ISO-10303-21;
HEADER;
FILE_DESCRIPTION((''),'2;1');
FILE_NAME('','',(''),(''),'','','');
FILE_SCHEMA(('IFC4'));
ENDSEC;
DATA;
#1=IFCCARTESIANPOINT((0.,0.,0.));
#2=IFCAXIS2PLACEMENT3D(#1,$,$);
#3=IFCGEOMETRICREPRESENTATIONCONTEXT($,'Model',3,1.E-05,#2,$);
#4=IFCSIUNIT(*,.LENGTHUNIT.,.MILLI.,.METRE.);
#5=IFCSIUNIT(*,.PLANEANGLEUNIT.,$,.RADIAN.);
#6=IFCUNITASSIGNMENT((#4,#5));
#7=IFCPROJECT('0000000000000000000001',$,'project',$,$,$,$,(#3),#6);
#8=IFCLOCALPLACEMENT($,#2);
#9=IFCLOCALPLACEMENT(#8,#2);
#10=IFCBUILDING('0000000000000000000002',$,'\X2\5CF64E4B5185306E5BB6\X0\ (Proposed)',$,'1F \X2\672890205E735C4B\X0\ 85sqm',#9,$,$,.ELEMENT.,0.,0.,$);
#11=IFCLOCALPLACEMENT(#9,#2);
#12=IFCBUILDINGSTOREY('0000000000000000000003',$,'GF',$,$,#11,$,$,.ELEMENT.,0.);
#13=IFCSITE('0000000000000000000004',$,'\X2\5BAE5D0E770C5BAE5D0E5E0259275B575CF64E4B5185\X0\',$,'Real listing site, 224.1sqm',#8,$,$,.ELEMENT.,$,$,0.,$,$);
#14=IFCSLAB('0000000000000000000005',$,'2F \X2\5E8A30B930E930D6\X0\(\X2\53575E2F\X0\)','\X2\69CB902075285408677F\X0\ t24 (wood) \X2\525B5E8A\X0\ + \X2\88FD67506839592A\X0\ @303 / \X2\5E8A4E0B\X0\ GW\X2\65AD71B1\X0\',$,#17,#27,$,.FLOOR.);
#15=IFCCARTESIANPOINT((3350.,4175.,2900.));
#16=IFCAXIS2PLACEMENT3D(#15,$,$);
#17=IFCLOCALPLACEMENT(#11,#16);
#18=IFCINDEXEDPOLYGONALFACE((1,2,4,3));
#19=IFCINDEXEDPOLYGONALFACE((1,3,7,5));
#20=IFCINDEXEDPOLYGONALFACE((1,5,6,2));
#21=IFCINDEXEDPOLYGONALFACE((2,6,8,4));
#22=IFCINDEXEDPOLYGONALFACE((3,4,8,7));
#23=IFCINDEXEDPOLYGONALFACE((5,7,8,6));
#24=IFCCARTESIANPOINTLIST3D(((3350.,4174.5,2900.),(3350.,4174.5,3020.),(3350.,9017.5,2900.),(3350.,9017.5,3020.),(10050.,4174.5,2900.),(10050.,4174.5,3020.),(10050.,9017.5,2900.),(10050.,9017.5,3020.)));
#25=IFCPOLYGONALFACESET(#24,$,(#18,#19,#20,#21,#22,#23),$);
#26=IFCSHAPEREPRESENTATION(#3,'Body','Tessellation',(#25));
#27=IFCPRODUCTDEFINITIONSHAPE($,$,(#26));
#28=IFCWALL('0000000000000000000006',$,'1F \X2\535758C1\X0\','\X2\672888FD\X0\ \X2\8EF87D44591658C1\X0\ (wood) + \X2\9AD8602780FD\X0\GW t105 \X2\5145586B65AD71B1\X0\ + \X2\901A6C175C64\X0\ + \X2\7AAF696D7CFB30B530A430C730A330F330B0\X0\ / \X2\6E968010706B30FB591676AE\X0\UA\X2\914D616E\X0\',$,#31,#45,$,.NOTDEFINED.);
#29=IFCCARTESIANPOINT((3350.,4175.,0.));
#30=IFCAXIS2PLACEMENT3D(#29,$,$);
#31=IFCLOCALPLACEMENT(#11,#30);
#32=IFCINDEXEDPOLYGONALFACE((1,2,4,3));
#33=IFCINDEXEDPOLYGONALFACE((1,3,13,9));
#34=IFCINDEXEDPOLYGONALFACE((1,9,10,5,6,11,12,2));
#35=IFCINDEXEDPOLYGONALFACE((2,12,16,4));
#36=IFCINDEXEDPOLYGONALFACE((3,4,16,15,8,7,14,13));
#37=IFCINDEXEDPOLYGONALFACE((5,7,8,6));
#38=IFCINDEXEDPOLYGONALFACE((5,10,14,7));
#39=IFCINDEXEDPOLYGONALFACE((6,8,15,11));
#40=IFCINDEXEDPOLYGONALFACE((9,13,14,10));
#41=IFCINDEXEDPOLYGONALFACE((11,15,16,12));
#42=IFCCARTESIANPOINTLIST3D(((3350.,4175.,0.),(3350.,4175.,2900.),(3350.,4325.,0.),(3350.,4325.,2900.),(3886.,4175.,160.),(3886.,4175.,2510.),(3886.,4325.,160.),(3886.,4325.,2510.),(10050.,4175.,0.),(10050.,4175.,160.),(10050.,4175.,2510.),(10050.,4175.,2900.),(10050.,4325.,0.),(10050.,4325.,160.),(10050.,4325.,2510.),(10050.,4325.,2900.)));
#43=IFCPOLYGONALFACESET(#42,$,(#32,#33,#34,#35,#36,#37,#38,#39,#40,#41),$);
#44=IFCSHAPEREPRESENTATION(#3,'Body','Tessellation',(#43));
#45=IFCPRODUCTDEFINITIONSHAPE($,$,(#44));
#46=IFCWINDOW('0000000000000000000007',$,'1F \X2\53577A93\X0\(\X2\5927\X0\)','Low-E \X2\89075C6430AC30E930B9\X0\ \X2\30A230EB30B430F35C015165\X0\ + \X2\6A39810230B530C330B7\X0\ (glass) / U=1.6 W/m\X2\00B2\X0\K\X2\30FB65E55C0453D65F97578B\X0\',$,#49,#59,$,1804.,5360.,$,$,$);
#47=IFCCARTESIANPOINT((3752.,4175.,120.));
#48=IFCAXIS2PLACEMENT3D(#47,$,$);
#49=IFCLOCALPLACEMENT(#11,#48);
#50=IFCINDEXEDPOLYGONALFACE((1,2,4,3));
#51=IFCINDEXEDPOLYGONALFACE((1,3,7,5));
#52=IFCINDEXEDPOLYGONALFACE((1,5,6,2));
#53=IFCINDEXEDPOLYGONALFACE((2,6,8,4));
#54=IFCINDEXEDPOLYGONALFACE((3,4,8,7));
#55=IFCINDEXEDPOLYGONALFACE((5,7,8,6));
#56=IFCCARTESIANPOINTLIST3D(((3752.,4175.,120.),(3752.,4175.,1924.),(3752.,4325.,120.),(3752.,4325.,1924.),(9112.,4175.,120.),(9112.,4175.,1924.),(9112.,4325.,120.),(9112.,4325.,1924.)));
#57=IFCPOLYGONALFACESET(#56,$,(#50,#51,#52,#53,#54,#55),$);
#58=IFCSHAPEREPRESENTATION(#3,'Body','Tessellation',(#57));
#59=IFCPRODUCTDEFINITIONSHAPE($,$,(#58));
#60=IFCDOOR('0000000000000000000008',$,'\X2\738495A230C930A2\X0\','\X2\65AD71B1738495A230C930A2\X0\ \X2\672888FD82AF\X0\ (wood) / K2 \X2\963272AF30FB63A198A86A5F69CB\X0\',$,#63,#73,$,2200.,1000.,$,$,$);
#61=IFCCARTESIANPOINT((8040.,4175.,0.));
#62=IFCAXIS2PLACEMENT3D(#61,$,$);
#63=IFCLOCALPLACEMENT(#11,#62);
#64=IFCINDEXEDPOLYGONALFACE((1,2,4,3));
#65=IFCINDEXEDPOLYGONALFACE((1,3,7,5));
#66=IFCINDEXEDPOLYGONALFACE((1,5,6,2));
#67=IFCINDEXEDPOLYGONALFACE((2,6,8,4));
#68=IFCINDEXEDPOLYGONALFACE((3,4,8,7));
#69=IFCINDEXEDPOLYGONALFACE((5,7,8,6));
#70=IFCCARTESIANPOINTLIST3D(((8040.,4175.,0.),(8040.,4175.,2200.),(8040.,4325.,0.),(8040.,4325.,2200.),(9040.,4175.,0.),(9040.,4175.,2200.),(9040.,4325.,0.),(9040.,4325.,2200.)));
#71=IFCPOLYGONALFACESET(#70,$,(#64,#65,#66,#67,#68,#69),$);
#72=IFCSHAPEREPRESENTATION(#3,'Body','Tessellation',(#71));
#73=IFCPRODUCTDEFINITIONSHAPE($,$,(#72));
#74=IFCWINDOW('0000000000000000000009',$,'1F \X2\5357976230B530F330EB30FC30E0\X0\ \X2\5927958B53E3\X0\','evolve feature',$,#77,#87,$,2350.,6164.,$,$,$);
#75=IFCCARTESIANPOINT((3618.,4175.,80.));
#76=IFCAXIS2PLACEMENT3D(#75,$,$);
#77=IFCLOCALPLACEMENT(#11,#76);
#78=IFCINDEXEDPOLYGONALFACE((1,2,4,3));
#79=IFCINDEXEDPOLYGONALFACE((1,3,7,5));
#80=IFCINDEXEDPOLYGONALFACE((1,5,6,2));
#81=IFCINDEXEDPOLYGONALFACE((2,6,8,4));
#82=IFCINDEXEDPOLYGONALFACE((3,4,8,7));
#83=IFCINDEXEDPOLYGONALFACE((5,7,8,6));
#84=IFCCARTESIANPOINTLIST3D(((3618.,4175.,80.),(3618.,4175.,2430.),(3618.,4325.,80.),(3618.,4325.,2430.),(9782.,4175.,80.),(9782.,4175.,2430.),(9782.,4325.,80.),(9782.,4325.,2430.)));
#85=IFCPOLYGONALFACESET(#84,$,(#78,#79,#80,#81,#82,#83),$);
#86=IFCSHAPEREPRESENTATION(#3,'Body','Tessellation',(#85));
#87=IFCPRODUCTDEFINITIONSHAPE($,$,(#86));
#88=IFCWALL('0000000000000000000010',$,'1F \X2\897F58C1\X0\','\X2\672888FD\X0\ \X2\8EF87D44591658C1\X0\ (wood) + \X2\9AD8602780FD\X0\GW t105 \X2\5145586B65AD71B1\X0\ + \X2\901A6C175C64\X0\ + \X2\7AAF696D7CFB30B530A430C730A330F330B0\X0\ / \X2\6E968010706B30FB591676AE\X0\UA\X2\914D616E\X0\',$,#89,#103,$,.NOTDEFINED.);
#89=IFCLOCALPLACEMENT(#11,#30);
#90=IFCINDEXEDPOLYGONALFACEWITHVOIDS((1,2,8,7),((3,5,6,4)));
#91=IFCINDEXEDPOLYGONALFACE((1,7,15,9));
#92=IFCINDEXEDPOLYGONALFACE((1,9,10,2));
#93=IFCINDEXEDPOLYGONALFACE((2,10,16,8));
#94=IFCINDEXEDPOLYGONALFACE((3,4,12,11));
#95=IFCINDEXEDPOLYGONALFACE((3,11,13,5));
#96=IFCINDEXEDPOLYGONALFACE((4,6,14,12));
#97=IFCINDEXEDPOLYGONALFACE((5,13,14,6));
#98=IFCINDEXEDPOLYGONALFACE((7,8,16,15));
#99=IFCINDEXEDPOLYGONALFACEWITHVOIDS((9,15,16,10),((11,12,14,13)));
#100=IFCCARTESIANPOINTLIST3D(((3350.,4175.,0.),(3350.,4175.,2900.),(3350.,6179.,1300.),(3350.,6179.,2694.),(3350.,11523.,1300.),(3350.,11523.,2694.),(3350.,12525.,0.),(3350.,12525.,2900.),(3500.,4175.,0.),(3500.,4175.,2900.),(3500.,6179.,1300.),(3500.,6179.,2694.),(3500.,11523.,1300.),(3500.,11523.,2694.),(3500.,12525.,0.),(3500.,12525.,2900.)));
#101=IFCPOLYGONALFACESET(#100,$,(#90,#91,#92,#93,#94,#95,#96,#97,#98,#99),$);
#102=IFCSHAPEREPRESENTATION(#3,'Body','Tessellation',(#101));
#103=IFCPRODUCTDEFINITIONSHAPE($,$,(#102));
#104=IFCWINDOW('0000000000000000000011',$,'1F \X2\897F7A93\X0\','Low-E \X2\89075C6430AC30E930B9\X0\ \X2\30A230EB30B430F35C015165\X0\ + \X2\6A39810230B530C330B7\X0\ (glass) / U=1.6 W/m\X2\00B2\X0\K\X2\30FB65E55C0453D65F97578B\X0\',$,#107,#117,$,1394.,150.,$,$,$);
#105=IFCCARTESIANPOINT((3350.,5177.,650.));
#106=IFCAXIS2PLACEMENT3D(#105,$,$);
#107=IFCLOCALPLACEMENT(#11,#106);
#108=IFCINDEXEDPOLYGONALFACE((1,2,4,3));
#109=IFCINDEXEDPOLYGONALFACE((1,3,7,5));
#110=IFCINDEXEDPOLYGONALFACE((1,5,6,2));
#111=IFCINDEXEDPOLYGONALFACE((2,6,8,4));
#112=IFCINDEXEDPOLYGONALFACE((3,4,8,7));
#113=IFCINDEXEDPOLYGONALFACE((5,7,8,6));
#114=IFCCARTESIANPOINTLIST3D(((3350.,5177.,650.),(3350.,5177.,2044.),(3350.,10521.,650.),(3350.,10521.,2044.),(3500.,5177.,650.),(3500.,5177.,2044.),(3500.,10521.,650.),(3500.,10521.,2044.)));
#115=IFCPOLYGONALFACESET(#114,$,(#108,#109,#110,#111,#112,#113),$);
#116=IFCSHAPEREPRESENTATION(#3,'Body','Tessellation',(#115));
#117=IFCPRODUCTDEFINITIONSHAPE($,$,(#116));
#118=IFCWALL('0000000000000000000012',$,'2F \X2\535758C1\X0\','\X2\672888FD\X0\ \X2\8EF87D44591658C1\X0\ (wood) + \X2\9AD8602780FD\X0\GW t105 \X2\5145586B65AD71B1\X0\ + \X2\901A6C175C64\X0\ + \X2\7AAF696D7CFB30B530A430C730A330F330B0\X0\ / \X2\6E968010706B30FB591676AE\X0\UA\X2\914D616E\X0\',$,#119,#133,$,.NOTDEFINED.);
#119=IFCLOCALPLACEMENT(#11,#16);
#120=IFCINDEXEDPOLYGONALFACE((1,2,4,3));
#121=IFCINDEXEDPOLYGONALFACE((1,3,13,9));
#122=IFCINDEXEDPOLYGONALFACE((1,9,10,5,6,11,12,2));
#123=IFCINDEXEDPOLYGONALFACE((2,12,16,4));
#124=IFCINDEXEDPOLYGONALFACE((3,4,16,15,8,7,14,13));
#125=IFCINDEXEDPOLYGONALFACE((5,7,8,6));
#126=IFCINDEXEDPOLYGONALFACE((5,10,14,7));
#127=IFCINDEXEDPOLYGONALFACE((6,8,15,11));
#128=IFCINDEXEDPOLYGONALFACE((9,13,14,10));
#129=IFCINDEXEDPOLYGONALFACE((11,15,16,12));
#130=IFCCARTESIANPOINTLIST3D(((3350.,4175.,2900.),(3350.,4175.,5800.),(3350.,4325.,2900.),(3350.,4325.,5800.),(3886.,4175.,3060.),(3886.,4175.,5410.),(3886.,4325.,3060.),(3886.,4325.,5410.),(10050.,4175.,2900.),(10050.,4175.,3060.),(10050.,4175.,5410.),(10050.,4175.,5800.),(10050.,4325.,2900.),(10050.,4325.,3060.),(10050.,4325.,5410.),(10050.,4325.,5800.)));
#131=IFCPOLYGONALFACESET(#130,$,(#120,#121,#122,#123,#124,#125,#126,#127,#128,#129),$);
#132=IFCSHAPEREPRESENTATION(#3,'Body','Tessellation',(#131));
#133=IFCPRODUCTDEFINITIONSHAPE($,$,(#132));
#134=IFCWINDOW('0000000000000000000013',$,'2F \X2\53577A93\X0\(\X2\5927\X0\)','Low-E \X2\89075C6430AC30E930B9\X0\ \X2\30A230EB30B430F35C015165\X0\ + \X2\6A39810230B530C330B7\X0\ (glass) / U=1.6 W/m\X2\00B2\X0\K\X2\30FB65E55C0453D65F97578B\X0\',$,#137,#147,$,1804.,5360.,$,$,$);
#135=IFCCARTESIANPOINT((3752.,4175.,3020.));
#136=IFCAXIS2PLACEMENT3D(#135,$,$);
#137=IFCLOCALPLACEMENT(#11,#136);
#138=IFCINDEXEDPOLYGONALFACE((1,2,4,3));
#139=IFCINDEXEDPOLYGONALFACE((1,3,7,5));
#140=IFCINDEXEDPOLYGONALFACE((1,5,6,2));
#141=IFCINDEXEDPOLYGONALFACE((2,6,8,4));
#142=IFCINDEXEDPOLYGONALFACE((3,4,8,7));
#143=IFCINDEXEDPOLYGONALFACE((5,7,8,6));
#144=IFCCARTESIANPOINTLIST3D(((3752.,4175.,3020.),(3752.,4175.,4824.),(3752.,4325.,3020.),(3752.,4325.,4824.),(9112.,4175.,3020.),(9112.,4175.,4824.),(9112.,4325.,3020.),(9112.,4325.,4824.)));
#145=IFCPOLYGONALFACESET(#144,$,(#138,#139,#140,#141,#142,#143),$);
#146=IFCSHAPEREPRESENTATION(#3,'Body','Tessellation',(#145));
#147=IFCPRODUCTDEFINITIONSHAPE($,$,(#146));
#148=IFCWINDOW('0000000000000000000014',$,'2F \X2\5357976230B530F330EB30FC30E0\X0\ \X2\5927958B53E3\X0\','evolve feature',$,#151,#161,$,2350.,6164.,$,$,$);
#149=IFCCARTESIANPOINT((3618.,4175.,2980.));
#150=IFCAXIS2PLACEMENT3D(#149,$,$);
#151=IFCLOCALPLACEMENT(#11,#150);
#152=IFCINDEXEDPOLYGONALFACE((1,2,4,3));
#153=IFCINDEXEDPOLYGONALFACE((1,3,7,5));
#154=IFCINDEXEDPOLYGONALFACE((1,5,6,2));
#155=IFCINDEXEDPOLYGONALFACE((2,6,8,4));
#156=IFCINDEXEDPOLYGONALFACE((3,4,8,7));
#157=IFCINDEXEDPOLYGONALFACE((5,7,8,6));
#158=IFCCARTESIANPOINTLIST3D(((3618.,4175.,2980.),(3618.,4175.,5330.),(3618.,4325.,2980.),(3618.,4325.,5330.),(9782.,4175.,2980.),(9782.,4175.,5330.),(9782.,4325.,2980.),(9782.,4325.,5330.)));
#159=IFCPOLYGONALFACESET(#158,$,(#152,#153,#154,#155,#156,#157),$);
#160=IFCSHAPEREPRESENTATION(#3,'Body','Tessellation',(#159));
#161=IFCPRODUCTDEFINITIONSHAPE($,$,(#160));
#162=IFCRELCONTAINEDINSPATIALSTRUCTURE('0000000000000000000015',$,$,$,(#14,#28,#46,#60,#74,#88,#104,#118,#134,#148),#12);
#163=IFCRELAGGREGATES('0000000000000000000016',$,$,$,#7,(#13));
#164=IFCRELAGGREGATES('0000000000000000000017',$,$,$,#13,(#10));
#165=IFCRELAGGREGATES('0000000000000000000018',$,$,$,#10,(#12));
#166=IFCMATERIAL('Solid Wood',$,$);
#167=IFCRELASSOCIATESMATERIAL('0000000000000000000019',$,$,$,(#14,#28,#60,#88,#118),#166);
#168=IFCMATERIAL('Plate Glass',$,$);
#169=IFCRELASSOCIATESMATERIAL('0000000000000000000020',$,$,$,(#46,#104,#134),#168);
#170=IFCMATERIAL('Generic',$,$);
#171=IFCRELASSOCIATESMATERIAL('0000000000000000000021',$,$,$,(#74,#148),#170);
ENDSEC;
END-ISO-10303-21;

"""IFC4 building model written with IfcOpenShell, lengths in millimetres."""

from ifc_helpers import new_model, si_unit, frame, frame_2d, origin, place, context, project, spatial, rectangle, extrude, material, element, fill, save


model = new_model("IFC4")

# Units and contexts
model_context = context("Model", 3, precision=1e-05, world=origin())
ifc_project = project(units=[si_unit("LENGTHUNIT", "METRE", prefix="MILLI"), si_unit("PLANEANGLEUNIT", "RADIAN")], contexts=[model_context])

# Site, building, storey
site_placement = place(None, origin())
site = spatial("IfcSite", under=ifc_project, at=site_placement, Name="宮崎県宮崎市大字島之内", ObjectType="Real listing site, 224.1sqm", CompositionType="ELEMENT", RefElevation=0.0)
building_placement = place(site_placement, origin())
building = spatial("IfcBuilding", under=site, at=building_placement, Name="島之内の家 (Proposed)", ObjectType="1F 木造平屋 85sqm", CompositionType="ELEMENT", ElevationOfRefHeight=0.0, ElevationOfTerrain=0.0)
storey_placement = place(building_placement, origin())
storey = spatial("IfcBuildingStorey", under=building, at=storey_placement, Name="GF", CompositionType="ELEMENT", Elevation=0.0)

# Slab
ifc_material_1 = material(Name="Solid Wood")
slab_1_placement = place(storey_placement, frame((3350.0, 4175.0, 2900.0)))
element("IfcSlab", 1, at=slab_1_placement, inside=storey, material=ifc_material_1, Name="2F 床スラブ(南帯)", Description="構造用合板 t24 (wood) 剛床 + 製材根太 @303 / 床下 GW断熱", PredefinedType="FLOOR", context=model_context, shape_type="SweptSolid", body=[
    extrude(rectangle(XDim=6700.0, YDim=4843.0, at=frame_2d((3350.0, 2421.0))), frame((3350.0, 4175.0, 2900.0)), (0.0, 0.0, 1.0), 120.0),
])
ifc_material_2 = material(Name="Generic")

# Wall, openings, windows, door
wall_1_placement = place(storey_placement, frame((3350.0, 4175.0, 0.0)))
wall_1 = element("IfcWall", 2, at=wall_1_placement, inside=storey, material=ifc_material_1, Name="1F 南壁", Description="木製 軸組外壁 (wood) + 高性能GW t105 充填断熱 + 通気層 + 窯業系サイディング / 準耐火・外皮UA配慮", PredefinedType="NOTDEFINED", context=model_context, shape_type="SweptSolid", body=[
    extrude(rectangle(XDim=6700.0, YDim=150.0, at=frame_2d((3350.0, 75.0))), frame((3350.0, 4175.0, 0.0)), (0.0, 0.0, 1.0), 2900.0),
])
opening_1_placement = place(storey_placement, frame((3752.0, 4175.0, 120.0)))
opening_1 = element("IfcOpeningElement", 3, at=opening_1_placement, cuts=wall_1, PredefinedType="NOTDEFINED", context=model_context, shape_type="SweptSolid", body=[
    extrude(rectangle(XDim=5360.0, YDim=150.0, at=frame_2d((2680.0, 75.0))), frame((3752.0, 4175.0, 120.0)), (0.0, 0.0, 1.0), 1804.0),
])
opening_2_placement = place(storey_placement, frame((8040.0, 4175.0, 0.0)))
opening_2 = element("IfcOpeningElement", 4, at=opening_2_placement, cuts=wall_1, PredefinedType="NOTDEFINED", context=model_context, shape_type="SweptSolid", body=[
    extrude(rectangle(XDim=1000.0, YDim=150.0, at=frame_2d((500.0, 75.0))), frame((8040.0, 4175.0, 0.0)), (0.0, 0.0, 1.0), 2200.0),
])
opening_3_placement = place(storey_placement, frame((3618.0, 4175.0, 80.0)))
opening_3 = element("IfcOpeningElement", 5, at=opening_3_placement, cuts=wall_1, PredefinedType="NOTDEFINED", context=model_context, shape_type="SweptSolid", body=[
    extrude(rectangle(XDim=6164.0, YDim=150.0, at=frame_2d((3082.0, 75.0))), frame((3618.0, 4175.0, 80.0)), (0.0, 0.0, 1.0), 2350.0),
])
ifc_material_3 = material(Name="Plate Glass")
window_1_placement = place(storey_placement, frame((3752.0, 4175.0, 120.0)))
window_1 = element("IfcWindow", 6, at=window_1_placement, inside=storey, material=ifc_material_3, Name="1F 南窓(大)", Description="Low-E 複層ガラス アルゴン封入 + 樹脂サッシ (glass) / U=1.6 W/m²K・日射取得型", OverallHeight=1804.0, OverallWidth=5360.0, context=model_context, shape_type="SweptSolid", body=[
    extrude(rectangle(XDim=5360.0, YDim=150.0, at=frame_2d((2680.0, 75.0))), frame((3752.0, 4175.0, 120.0)), (0.0, 0.0, 1.0), 1804.0),
])
fill(opening_1, window_1)
door_placement = place(storey_placement, frame((8040.0, 4175.0, 0.0)))
door = element("IfcDoor", 7, at=door_placement, inside=storey, material=ifc_material_1, Name="玄関ドア", Description="断熱玄関ドア 木製芯 (wood) / K2 防犯・採風機構", OverallHeight=2200.0, OverallWidth=1000.0, context=model_context, shape_type="SweptSolid", body=[
    extrude(rectangle(XDim=1000.0, YDim=150.0, at=frame_2d((500.0, 75.0))), frame((8040.0, 4175.0, 0.0)), (0.0, 0.0, 1.0), 2200.0),
])
fill(opening_2, door)
window_2_placement = place(storey_placement, frame((3618.0, 4175.0, 80.0)))
window_2 = element("IfcWindow", 8, at=window_2_placement, inside=storey, material=ifc_material_2, Name="1F 南面サンルーム 大開口", Description="evolve feature", OverallHeight=2350.0, OverallWidth=6164.0, context=model_context, shape_type="SweptSolid", body=[
    extrude(rectangle(XDim=6164.0, YDim=150.0, at=frame_2d((3082.0, 75.0))), frame((3618.0, 4175.0, 80.0)), (0.0, 0.0, 1.0), 2350.0),
])
fill(opening_3, window_2)

# Wall, opening, window
wall_2_placement = place(storey_placement, frame((3350.0, 4175.0, 0.0)))
wall_2 = element("IfcWall", 9, at=wall_2_placement, inside=storey, material=ifc_material_1, Name="1F 西壁", Description="木製 軸組外壁 (wood) + 高性能GW t105 充填断熱 + 通気層 + 窯業系サイディング / 準耐火・外皮UA配慮", PredefinedType="NOTDEFINED", context=model_context, shape_type="SweptSolid", body=[
    extrude(rectangle(XDim=150.0, YDim=8350.0, at=frame_2d((75.0, 4175.0))), frame((3350.0, 4175.0, 0.0)), (0.0, 0.0, 1.0), 2900.0),
])
opening_4_placement = place(storey_placement, frame((3350.0, 5177.0, 650.0)))
opening_4 = element("IfcOpeningElement", 10, at=opening_4_placement, cuts=wall_2, PredefinedType="NOTDEFINED", context=model_context, shape_type="SweptSolid", body=[
    extrude(rectangle(XDim=150.0, YDim=5344.0, at=frame_2d((75.0, 2672.0))), frame((3350.0, 5177.0, 650.0)), (0.0, 0.0, 1.0), 1394.0),
])
window_3_placement = place(storey_placement, frame((3350.0, 5177.0, 650.0)))
window_3 = element("IfcWindow", 11, at=window_3_placement, inside=storey, material=ifc_material_3, Name="1F 西窓", Description="Low-E 複層ガラス アルゴン封入 + 樹脂サッシ (glass) / U=1.6 W/m²K・日射取得型", OverallHeight=1394.0, OverallWidth=150.0, context=model_context, shape_type="SweptSolid", body=[
    extrude(rectangle(XDim=150.0, YDim=5344.0, at=frame_2d((75.0, 2672.0))), frame((3350.0, 5177.0, 650.0)), (0.0, 0.0, 1.0), 1394.0),
])
fill(opening_4, window_3)

# Wall, openings, windows
wall_3_placement = place(storey_placement, frame((3350.0, 4175.0, 2900.0)))
wall_3 = element("IfcWall", 12, at=wall_3_placement, inside=storey, material=ifc_material_1, Name="2F 南壁", Description="木製 軸組外壁 (wood) + 高性能GW t105 充填断熱 + 通気層 + 窯業系サイディング / 準耐火・外皮UA配慮", PredefinedType="NOTDEFINED", context=model_context, shape_type="SweptSolid", body=[
    extrude(rectangle(XDim=6700.0, YDim=150.0, at=frame_2d((3350.0, 75.0))), frame((3350.0, 4175.0, 2900.0)), (0.0, 0.0, 1.0), 2900.0),
])
opening_5_placement = place(storey_placement, frame((3752.0, 4175.0, 3020.0)))
opening_5 = element("IfcOpeningElement", 13, at=opening_5_placement, cuts=wall_3, PredefinedType="NOTDEFINED", context=model_context, shape_type="SweptSolid", body=[
    extrude(rectangle(XDim=5360.0, YDim=150.0, at=frame_2d((2680.0, 75.0))), frame((3752.0, 4175.0, 3020.0)), (0.0, 0.0, 1.0), 1804.0),
])
opening_6_placement = place(storey_placement, frame((3618.0, 4175.0, 2980.0)))
opening_6 = element("IfcOpeningElement", 14, at=opening_6_placement, cuts=wall_3, PredefinedType="NOTDEFINED", context=model_context, shape_type="SweptSolid", body=[
    extrude(rectangle(XDim=6164.0, YDim=150.0, at=frame_2d((3082.0, 75.0))), frame((3618.0, 4175.0, 2980.0)), (0.0, 0.0, 1.0), 2350.0),
])
window_4_placement = place(storey_placement, frame((3752.0, 4175.0, 3020.0)))
window_4 = element("IfcWindow", 15, at=window_4_placement, inside=storey, material=ifc_material_3, Name="2F 南窓(大)", Description="Low-E 複層ガラス アルゴン封入 + 樹脂サッシ (glass) / U=1.6 W/m²K・日射取得型", OverallHeight=1804.0, OverallWidth=5360.0, context=model_context, shape_type="SweptSolid", body=[
    extrude(rectangle(XDim=5360.0, YDim=150.0, at=frame_2d((2680.0, 75.0))), frame((3752.0, 4175.0, 3020.0)), (0.0, 0.0, 1.0), 1804.0),
])
fill(opening_5, window_4)
window_5_placement = place(storey_placement, frame((3618.0, 4175.0, 2980.0)))
window_5 = element("IfcWindow", 16, at=window_5_placement, inside=storey, material=ifc_material_2, Name="2F 南面サンルーム 大開口", Description="evolve feature", OverallHeight=2350.0, OverallWidth=6164.0, context=model_context, shape_type="SweptSolid", body=[
    extrude(rectangle(XDim=6164.0, YDim=150.0, at=frame_2d((3082.0, 75.0))), frame((3618.0, 4175.0, 2980.0)), (0.0, 0.0, 1.0), 2350.0),
])
fill(opening_6, window_5)

save(model, "model.ifc")
